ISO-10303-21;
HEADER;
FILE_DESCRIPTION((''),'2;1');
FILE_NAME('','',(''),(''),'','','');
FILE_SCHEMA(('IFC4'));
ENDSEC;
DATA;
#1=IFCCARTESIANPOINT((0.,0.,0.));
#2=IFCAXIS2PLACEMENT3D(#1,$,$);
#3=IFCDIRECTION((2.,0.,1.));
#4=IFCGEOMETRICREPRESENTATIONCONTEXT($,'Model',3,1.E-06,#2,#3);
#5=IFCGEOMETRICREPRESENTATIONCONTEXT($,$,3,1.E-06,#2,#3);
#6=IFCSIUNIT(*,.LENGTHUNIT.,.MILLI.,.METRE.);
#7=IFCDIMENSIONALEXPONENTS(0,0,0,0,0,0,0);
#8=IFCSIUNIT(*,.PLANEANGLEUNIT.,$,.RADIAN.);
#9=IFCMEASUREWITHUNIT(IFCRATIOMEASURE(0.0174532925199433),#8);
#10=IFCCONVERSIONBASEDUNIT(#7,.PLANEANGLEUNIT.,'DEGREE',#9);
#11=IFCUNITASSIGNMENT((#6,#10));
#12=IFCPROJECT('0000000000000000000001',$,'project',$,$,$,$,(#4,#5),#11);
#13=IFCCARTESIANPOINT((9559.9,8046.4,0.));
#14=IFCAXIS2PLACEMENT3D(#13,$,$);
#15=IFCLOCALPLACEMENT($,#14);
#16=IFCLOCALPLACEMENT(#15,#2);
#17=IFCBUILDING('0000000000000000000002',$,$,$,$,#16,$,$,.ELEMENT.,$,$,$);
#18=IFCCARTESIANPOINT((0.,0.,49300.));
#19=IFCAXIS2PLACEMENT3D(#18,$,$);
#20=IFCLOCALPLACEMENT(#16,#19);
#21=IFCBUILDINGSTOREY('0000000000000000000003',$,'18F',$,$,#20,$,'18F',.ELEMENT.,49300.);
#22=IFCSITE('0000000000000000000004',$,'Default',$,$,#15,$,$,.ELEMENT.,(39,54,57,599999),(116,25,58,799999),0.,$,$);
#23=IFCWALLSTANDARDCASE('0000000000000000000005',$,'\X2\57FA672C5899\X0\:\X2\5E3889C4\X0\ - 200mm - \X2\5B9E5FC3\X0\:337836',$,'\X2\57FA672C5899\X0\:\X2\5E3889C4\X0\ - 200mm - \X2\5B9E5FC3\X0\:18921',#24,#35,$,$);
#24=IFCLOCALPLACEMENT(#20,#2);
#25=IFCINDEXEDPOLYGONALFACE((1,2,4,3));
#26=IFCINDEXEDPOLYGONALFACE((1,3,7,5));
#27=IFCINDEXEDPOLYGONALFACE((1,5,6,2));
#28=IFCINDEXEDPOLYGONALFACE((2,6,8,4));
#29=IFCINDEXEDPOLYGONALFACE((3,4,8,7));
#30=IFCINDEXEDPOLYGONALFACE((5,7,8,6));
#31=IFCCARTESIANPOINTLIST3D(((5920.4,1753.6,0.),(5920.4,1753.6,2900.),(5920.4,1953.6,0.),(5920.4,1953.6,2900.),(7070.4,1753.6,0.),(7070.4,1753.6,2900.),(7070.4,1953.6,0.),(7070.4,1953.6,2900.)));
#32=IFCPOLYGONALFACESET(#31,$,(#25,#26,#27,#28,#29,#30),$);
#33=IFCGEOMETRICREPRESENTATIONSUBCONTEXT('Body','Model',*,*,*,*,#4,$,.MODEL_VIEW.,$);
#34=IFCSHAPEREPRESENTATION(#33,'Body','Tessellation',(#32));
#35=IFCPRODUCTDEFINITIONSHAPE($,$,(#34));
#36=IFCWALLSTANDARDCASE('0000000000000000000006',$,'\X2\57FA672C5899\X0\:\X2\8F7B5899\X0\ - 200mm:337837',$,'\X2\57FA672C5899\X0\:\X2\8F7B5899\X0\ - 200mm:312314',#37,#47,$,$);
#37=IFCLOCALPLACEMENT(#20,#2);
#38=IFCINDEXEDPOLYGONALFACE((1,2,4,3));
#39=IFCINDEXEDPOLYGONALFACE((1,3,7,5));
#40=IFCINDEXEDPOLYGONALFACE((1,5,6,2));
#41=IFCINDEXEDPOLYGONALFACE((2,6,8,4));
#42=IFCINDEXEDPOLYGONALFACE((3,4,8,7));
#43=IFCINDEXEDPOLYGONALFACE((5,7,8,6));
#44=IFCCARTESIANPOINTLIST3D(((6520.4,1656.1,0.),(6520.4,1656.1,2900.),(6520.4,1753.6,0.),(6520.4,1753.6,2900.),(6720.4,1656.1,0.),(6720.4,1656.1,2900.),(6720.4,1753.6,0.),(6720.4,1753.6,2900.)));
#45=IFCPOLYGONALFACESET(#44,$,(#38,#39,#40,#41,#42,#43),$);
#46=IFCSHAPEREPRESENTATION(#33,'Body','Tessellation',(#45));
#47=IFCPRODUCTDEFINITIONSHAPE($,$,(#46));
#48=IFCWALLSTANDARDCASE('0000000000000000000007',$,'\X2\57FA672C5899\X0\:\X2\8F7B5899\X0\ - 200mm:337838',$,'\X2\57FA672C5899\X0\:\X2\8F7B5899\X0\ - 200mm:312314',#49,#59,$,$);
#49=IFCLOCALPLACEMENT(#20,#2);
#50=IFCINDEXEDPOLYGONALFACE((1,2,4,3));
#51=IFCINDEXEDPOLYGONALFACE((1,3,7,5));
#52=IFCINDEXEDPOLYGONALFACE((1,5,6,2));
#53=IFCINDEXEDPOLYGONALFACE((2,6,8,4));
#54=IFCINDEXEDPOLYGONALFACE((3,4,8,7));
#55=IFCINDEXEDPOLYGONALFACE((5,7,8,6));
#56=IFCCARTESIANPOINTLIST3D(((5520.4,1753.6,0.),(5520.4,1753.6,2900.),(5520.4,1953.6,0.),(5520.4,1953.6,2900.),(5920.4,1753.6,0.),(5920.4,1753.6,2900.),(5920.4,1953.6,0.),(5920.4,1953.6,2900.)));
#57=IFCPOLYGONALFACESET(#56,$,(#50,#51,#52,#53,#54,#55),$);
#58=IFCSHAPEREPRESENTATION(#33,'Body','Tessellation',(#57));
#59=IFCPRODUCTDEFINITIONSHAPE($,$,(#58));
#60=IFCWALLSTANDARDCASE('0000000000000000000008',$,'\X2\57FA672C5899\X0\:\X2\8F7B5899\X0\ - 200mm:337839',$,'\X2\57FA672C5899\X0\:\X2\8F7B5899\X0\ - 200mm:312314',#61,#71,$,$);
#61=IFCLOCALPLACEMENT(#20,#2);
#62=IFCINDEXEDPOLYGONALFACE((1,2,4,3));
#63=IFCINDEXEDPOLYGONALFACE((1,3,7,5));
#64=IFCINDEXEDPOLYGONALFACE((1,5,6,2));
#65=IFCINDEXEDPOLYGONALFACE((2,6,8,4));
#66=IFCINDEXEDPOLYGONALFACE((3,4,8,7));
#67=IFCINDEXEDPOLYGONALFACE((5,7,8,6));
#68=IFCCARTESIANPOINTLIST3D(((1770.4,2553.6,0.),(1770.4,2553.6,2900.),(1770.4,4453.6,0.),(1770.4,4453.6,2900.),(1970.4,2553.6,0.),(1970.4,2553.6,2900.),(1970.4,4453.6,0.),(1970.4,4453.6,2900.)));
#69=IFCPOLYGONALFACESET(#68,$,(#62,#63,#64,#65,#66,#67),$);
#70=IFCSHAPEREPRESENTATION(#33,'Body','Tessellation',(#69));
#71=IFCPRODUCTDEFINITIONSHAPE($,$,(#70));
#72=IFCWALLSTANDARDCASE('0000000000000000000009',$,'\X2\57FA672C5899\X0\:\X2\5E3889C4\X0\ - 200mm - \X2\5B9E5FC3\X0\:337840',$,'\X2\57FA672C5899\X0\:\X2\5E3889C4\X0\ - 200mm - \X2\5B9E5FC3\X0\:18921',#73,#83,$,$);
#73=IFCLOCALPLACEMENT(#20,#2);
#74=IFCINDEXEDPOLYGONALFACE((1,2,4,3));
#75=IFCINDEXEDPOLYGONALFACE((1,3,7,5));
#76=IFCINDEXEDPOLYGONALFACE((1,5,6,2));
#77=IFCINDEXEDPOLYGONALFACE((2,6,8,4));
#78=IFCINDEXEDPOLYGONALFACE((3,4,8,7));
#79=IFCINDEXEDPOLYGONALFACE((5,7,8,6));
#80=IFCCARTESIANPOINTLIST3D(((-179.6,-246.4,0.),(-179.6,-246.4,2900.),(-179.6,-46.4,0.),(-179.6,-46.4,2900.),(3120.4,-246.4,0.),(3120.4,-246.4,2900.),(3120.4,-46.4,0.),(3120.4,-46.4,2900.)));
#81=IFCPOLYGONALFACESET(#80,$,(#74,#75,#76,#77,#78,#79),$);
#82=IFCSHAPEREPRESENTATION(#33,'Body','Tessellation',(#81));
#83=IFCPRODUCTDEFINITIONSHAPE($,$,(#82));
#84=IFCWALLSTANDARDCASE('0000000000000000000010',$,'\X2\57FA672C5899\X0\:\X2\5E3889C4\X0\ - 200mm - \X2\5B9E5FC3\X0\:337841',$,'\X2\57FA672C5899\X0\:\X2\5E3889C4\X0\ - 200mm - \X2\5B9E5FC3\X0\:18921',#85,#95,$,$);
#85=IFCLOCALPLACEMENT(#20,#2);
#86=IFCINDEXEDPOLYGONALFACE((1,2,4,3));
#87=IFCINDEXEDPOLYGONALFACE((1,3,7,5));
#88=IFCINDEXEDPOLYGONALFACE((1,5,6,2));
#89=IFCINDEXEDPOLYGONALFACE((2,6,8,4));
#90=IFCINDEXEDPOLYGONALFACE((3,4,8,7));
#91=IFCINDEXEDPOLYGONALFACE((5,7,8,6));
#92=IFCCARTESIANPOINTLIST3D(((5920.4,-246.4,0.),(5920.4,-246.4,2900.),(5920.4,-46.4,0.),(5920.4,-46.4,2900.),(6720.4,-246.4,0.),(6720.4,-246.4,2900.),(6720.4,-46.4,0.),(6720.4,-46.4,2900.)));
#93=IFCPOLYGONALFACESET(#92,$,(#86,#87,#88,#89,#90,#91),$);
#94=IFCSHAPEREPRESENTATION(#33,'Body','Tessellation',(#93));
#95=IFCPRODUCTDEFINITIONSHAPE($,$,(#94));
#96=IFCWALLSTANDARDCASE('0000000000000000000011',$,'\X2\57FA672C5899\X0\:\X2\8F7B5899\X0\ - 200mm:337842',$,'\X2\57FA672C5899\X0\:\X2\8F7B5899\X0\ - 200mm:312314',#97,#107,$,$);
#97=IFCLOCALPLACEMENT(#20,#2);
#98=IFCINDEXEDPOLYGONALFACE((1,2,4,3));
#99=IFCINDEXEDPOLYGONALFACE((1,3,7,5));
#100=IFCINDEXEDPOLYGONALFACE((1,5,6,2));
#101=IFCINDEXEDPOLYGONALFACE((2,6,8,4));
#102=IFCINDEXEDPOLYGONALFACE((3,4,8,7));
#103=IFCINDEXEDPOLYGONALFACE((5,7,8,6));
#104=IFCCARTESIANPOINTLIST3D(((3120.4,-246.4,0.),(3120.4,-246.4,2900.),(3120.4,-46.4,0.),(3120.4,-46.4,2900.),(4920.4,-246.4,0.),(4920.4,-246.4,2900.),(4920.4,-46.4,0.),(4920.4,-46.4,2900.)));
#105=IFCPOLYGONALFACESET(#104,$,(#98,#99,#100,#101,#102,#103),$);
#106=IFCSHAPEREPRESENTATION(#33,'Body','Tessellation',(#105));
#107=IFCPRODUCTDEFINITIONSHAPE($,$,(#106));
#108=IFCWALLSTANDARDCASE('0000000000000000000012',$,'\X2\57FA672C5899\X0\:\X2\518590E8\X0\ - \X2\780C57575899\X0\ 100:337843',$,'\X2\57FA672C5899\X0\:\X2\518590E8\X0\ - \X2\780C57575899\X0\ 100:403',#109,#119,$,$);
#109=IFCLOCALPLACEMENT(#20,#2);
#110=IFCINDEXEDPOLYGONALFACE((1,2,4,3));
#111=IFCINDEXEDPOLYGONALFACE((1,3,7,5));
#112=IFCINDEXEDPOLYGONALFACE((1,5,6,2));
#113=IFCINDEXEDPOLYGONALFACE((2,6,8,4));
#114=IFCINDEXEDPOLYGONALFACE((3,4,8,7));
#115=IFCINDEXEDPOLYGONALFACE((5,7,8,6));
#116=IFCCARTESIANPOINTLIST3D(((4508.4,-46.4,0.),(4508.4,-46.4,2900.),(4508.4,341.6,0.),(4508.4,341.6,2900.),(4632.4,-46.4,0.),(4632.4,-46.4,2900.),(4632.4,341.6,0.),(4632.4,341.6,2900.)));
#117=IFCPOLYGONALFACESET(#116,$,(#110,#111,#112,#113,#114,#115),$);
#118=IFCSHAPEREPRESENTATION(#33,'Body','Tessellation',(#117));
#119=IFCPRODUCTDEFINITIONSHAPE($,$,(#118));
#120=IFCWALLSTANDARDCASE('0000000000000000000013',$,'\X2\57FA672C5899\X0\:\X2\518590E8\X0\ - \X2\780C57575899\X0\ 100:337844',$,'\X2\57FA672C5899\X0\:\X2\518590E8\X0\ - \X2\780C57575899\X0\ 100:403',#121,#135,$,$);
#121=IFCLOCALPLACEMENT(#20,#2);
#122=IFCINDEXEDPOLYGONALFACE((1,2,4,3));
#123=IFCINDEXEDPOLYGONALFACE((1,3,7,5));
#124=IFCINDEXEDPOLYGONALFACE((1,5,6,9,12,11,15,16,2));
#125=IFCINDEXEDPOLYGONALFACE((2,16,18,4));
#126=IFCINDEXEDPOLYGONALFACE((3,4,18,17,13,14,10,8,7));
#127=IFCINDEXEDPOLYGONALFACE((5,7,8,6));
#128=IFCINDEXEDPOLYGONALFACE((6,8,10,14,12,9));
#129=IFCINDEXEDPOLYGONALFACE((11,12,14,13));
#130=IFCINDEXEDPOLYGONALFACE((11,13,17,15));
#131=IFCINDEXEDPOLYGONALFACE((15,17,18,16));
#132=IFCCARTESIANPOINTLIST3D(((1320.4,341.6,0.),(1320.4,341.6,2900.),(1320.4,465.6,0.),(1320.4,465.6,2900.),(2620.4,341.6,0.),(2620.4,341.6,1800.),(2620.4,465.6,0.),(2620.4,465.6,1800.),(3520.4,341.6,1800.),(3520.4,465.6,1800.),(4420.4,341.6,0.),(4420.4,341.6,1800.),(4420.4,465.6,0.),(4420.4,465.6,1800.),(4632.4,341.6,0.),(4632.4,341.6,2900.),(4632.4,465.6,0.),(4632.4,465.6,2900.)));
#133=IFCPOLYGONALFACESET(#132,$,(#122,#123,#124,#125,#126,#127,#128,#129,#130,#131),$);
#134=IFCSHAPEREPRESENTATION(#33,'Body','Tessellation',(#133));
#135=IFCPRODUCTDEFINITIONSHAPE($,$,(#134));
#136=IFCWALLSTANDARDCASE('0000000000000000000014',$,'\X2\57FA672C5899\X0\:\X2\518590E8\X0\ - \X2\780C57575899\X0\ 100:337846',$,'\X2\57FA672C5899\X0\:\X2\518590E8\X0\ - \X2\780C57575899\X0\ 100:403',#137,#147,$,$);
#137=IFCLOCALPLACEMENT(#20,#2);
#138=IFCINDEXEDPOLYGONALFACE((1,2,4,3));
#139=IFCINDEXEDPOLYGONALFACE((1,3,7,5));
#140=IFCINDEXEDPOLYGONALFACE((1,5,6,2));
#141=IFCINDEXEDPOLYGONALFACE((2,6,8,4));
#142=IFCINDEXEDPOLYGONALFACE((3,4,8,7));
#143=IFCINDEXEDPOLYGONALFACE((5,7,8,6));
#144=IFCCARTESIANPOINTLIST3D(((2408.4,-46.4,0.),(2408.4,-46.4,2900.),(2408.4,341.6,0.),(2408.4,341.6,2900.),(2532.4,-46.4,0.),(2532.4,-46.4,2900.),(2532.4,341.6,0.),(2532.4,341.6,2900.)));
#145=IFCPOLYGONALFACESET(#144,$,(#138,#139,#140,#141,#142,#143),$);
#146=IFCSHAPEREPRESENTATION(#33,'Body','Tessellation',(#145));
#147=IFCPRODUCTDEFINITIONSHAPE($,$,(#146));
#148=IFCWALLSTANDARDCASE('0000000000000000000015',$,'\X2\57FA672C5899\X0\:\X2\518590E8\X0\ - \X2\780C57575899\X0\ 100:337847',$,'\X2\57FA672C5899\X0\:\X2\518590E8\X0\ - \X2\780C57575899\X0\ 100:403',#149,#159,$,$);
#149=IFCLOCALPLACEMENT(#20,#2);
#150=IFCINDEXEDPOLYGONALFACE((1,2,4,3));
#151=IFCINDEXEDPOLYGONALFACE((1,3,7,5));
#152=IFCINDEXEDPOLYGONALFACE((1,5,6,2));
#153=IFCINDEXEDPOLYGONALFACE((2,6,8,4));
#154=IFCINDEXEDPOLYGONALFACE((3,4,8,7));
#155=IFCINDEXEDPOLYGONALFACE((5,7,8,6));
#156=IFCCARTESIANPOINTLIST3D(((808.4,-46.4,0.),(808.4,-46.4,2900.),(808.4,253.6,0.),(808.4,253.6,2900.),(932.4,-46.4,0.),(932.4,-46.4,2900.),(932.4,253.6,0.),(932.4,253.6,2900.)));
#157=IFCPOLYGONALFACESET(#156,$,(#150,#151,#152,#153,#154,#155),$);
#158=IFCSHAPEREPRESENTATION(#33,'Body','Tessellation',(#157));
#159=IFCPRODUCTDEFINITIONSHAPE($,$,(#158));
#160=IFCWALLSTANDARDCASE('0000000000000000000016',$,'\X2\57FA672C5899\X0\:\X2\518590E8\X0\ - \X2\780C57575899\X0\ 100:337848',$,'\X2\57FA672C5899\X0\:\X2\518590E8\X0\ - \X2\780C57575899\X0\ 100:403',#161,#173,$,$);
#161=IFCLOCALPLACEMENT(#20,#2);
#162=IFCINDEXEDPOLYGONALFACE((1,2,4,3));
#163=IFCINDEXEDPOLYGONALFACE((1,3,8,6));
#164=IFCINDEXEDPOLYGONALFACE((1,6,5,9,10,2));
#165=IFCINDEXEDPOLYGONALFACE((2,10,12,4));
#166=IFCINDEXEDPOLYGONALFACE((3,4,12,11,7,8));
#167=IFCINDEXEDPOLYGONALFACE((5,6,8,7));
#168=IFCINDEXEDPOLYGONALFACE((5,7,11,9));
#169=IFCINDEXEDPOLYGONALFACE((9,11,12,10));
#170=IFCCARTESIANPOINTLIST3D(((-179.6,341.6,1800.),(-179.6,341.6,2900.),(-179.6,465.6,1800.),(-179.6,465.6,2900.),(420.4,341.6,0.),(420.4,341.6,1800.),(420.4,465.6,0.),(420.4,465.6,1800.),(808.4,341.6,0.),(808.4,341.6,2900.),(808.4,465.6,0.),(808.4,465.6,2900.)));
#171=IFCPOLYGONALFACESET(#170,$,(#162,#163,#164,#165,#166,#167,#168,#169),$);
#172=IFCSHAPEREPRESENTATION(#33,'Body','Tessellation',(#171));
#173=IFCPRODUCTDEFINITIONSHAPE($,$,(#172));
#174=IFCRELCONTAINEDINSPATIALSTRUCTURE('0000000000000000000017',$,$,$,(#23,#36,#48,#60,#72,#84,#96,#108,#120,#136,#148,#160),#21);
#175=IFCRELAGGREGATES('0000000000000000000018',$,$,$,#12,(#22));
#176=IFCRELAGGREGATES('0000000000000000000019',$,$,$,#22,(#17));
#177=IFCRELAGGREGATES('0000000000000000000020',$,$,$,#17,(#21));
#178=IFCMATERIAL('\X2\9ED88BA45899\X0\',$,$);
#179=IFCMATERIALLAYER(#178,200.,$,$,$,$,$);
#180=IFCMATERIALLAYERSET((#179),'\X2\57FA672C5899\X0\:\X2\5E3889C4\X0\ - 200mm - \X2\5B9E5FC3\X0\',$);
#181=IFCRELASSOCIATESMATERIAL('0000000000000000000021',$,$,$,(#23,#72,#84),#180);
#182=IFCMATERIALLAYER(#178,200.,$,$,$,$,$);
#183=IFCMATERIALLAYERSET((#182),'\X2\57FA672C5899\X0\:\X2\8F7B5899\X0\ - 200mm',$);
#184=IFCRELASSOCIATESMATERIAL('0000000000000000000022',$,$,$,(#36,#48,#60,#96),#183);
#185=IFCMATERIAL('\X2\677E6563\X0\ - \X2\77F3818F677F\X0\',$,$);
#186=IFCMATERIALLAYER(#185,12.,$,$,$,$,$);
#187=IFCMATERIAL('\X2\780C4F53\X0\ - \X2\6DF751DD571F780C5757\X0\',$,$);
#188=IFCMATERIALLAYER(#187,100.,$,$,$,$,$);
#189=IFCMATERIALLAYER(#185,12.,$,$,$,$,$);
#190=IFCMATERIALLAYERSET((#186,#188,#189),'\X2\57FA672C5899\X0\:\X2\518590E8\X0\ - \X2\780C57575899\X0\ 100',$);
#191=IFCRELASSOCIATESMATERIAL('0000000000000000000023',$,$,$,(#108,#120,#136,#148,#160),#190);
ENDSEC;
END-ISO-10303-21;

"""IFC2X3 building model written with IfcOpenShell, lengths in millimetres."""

from ifc_helpers import new_model, entity, si_unit, converted_unit, direction, frame, frame_2d, origin, place, context, subcontext, project, spatial, rectangle, extrude, material, layer, layer_set, layer_usage, element, save


model = new_model("IFC2X3")

# Units and contexts
model_context = context("Model", 3, precision=1e-06, world=origin(), true_north=direction((2.0, 0.0, 1.0)))
context_of_model = context(None, 3, precision=1e-06, world=origin(), true_north=direction((2.0, 0.0, 1.0)))
body_context = subcontext(model_context, "Body", "Model", "MODEL_VIEW")
ifc_project = project(units=[si_unit("LENGTHUNIT", "METRE", prefix="MILLI"), converted_unit("PLANEANGLEUNIT", "DEGREE", entity("IfcRatioMeasure", 0.0174532925199433), si_unit("PLANEANGLEUNIT", "RADIAN"), dimensions=[0, 0, 0, 0, 0, 0, 0])], contexts=[model_context, context_of_model])

# Site, building, storey
site_placement = place(None, frame((9559.9, 8046.4, 0.0)))
site = spatial("IfcSite", under=ifc_project, at=site_placement, Name="Default", CompositionType="ELEMENT", RefLatitude=(39, 54, 57, 599999), RefLongitude=(116, 25, 58, 799999), RefElevation=0.0)
building_placement = place(site_placement, origin())
building = spatial("IfcBuilding", under=site, at=building_placement, CompositionType="ELEMENT")
storey_placement = place(building_placement, frame((0.0, 0.0, 49300.0)))
storey = spatial("IfcBuildingStorey", under=building, at=storey_placement, Name="18F", LongName="18F", CompositionType="ELEMENT", Elevation=49300.0)

# Shared definitions
ifc_material_1 = material(Name="默认墙")
ifc_layer_1 = layer(ifc_material_1, 200.0)
ifc_layer_set_1 = layer_set([ifc_layer_1], Name="基本墙:常规 - 200mm - 实心")

# Walls
ifc_layer_usage_1 = layer_usage(ifc_layer_set_1, "AXIS2", "NEGATIVE", 100.0)
wall_1_placement = place(storey_placement, frame((5920.4, 1853.6, 0.0)))
element("IfcWallStandardCase", 1, at=wall_1_placement, inside=storey, material=ifc_layer_usage_1, Name="基本墙:常规 - 200mm - 实心:337836", ObjectType="基本墙:常规 - 200mm - 实心:18921", context=body_context, shape_type="SweptSolid", body=[
    extrude(rectangle(XDim=1150.0, YDim=200.0, at=frame_2d((575.0, 0.0), x_axis=(-1.0, 0.0))), origin(), (0.0, 0.0, 1.0), 2900.0),
])
ifc_layer_2 = layer(ifc_material_1, 200.0)
ifc_layer_set_2 = layer_set([ifc_layer_2], Name="基本墙:轻墙 - 200mm")
ifc_layer_usage_2 = layer_usage(ifc_layer_set_2, "AXIS2", "NEGATIVE", 100.0)
wall_2_placement = place(storey_placement, frame((6620.4, 1753.6, 0.0), z_axis=(0.0, 0.0, 1.0), x_axis=(0.0, -1.0, 0.0)))
element("IfcWallStandardCase", 2, at=wall_2_placement, inside=storey, material=ifc_layer_usage_2, Name="基本墙:轻墙 - 200mm:337837", ObjectType="基本墙:轻墙 - 200mm:312314", context=body_context, shape_type="SweptSolid", body=[
    extrude(rectangle(XDim=97.5, YDim=200.0, at=frame_2d((48.8, 0.0), x_axis=(-1.0, 0.0))), origin(), (0.0, 0.0, 1.0), 2900.0),
])
ifc_layer_usage_3 = layer_usage(ifc_layer_set_2, "AXIS2", "NEGATIVE", 100.0)
wall_3_placement = place(storey_placement, frame((5920.4, 1853.6, 0.0), z_axis=(0.0, 0.0, 1.0), x_axis=(-1.0, 0.0, 0.0)))
element("IfcWallStandardCase", 3, at=wall_3_placement, inside=storey, material=ifc_layer_usage_3, Name="基本墙:轻墙 - 200mm:337838", ObjectType="基本墙:轻墙 - 200mm:312314", context=body_context, shape_type="SweptSolid", body=[
    extrude(rectangle(XDim=400.0, YDim=200.0, at=frame_2d((200.0, 0.0), x_axis=(-1.0, 0.0))), origin(), (0.0, 0.0, 1.0), 2900.0),
])
ifc_layer_usage_4 = layer_usage(ifc_layer_set_2, "AXIS2", "NEGATIVE", 100.0)
wall_4_placement = place(storey_placement, frame((1870.4, 4453.6, 0.0), z_axis=(0.0, 0.0, 1.0), x_axis=(0.0, -1.0, 0.0)))
element("IfcWallStandardCase", 4, at=wall_4_placement, inside=storey, material=ifc_layer_usage_4, Name="基本墙:轻墙 - 200mm:337839", ObjectType="基本墙:轻墙 - 200mm:312314", context=body_context, shape_type="SweptSolid", body=[
    extrude(rectangle(XDim=1900.0, YDim=200.0, at=frame_2d((950.0, 0.0), x_axis=(-1.0, 0.0))), origin(), (0.0, 0.0, 1.0), 2900.0),
])
ifc_layer_usage_5 = layer_usage(ifc_layer_set_1, "AXIS2", "NEGATIVE", 100.0)
wall_5_placement = place(storey_placement, frame((-179.6, -146.4, 0.0)))
element("IfcWallStandardCase", 5, at=wall_5_placement, inside=storey, material=ifc_layer_usage_5, Name="基本墙:常规 - 200mm - 实心:337840", ObjectType="基本墙:常规 - 200mm - 实心:18921", context=body_context, shape_type="SweptSolid", body=[
    extrude(rectangle(XDim=3300.0, YDim=200.0, at=frame_2d((1650.0, 0.0), x_axis=(-1.0, 0.0))), origin(), (0.0, 0.0, 1.0), 2900.0),
])
ifc_layer_usage_6 = layer_usage(ifc_layer_set_1, "AXIS2", "NEGATIVE", 100.0)
wall_6_placement = place(storey_placement, frame((6720.4, -146.4, 0.0), z_axis=(0.0, 0.0, 1.0), x_axis=(-1.0, 0.0, 0.0)))
element("IfcWallStandardCase", 6, at=wall_6_placement, inside=storey, material=ifc_layer_usage_6, Name="基本墙:常规 - 200mm - 实心:337841", ObjectType="基本墙:常规 - 200mm - 实心:18921", context=body_context, shape_type="SweptSolid", body=[
    extrude(rectangle(XDim=800.0, YDim=200.0, at=frame_2d((400.0, 0.0), x_axis=(-1.0, 0.0))), origin(), (0.0, 0.0, 1.0), 2900.0),
])
ifc_layer_usage_7 = layer_usage(ifc_layer_set_2, "AXIS2", "NEGATIVE", 100.0)
wall_7_placement = place(storey_placement, frame((3120.4, -146.4, 0.0)))
element("IfcWallStandardCase", 7, at=wall_7_placement, inside=storey, material=ifc_layer_usage_7, Name="基本墙:轻墙 - 200mm:337842", ObjectType="基本墙:轻墙 - 200mm:312314", context=body_context, shape_type="SweptSolid", body=[
    extrude(rectangle(XDim=1800.0, YDim=200.0, at=frame_2d((900.0, 0.0), x_axis=(-1.0, 0.0))), origin(), (0.0, 0.0, 1.0), 2900.0),
])
ifc_material_2 = material(Name="松散 - 石膏板")
ifc_layer_3 = layer(ifc_material_2, 12.0)
ifc_material_3 = material(Name="砌体 - 混凝土砌块")
ifc_layer_4 = layer(ifc_material_3, 100.0)
ifc_layer_5 = layer(ifc_material_2, 12.0)
ifc_layer_set_3 = layer_set([ifc_layer_3, ifc_layer_4, ifc_layer_5], Name="基本墙:内部 - 砌块墙 100")
ifc_layer_usage_8 = layer_usage(ifc_layer_set_3, "AXIS2", "NEGATIVE", 62.0)
wall_8_placement = place(storey_placement, frame((4570.4, -46.4, 0.0), z_axis=(0.0, 0.0, 1.0), x_axis=(0.0, 1.0, 0.0)))
element("IfcWallStandardCase", 8, at=wall_8_placement, inside=storey, material=ifc_layer_usage_8, Name="基本墙:内部 - 砌块墙 100:337843", ObjectType="基本墙:内部 - 砌块墙 100:403", context=body_context, shape_type="SweptSolid", body=[
    extrude(rectangle(XDim=388.0, YDim=124.0, at=frame_2d((194.0, 0.0), x_axis=(-1.0, 0.0))), origin(), (0.0, 0.0, 1.0), 2900.0),
])

# Wall, openings
ifc_layer_usage_9 = layer_usage(ifc_layer_set_3, "AXIS2", "NEGATIVE", 62.0)
wall_9_placement = place(storey_placement, frame((4632.4, 403.6, 0.0), z_axis=(0.0, 0.0, 1.0), x_axis=(-1.0, 0.0, 0.0)))
wall_9 = element("IfcWallStandardCase", 9, at=wall_9_placement, inside=storey, material=ifc_layer_usage_9, Name="基本墙:内部 - 砌块墙 100:337844", ObjectType="基本墙:内部 - 砌块墙 100:403", context=body_context, shape_type="SweptSolid", body=[
    extrude(rectangle(XDim=3312.0, YDim=124.0, at=frame_2d((1656.0, 0.0), x_axis=(-1.0, 0.0))), origin(), (0.0, 0.0, 1.0), 2900.0),
])
opening_1_placement = place(wall_9_placement, frame((2012.0, 62.0, 0.0)))
element("IfcOpeningElement", 10, at=opening_1_placement, cuts=wall_9, ObjectType="Opening", context=body_context, shape_type="SweptSolid", body=[
    extrude(rectangle(XDim=1800.0, YDim=900.0, at=frame_2d((900.0, 450.0), x_axis=(1.0, 0.0))), frame((0.0, 0.0, 0.0), z_axis=(0.0, -1.0, 0.0), x_axis=(0.0, 0.0, 1.0)), (0.0, 0.0, 1.0), 124.0),
])
opening_2_placement = place(wall_9_placement, frame((1112.0, 62.0, 0.0)))
element("IfcOpeningElement", 11, at=opening_2_placement, cuts=wall_9, ObjectType="Opening", context=body_context, shape_type="SweptSolid", body=[
    extrude(rectangle(XDim=1800.0, YDim=900.0, at=frame_2d((900.0, 450.0), x_axis=(1.0, 0.0))), frame((0.0, 0.0, 0.0), z_axis=(0.0, -1.0, 0.0), x_axis=(0.0, 0.0, 1.0)), (0.0, 0.0, 1.0), 124.0),
])

# Walls
ifc_layer_usage_10 = layer_usage(ifc_layer_set_3, "AXIS2", "NEGATIVE", 62.0)
wall_10_placement = place(storey_placement, frame((2470.4, 341.6, 0.0), z_axis=(0.0, 0.0, 1.0), x_axis=(0.0, -1.0, 0.0)))
element("IfcWallStandardCase", 12, at=wall_10_placement, inside=storey, material=ifc_layer_usage_10, Name="基本墙:内部 - 砌块墙 100:337846", ObjectType="基本墙:内部 - 砌块墙 100:403", context=body_context, shape_type="SweptSolid", body=[
    extrude(rectangle(XDim=388.0, YDim=124.0, at=frame_2d((194.0, 0.0), x_axis=(-1.0, 0.0))), origin(), (0.0, 0.0, 1.0), 2900.0),
])
ifc_layer_usage_11 = layer_usage(ifc_layer_set_3, "AXIS2", "NEGATIVE", 62.0)
wall_11_placement = place(storey_placement, frame((870.4, -46.4, 0.0), z_axis=(0.0, 0.0, 1.0), x_axis=(0.0, 1.0, 0.0)))
element("IfcWallStandardCase", 13, at=wall_11_placement, inside=storey, material=ifc_layer_usage_11, Name="基本墙:内部 - 砌块墙 100:337847", ObjectType="基本墙:内部 - 砌块墙 100:403", context=body_context, shape_type="SweptSolid", body=[
    extrude(rectangle(XDim=300.0, YDim=124.0, at=frame_2d((150.0, 0.0), x_axis=(-1.0, 0.0))), origin(), (0.0, 0.0, 1.0), 2900.0),
])

# Wall, opening
ifc_layer_usage_12 = layer_usage(ifc_layer_set_3, "AXIS2", "NEGATIVE", 62.0)
wall_12_placement = place(storey_placement, frame((808.4, 403.6, 0.0), z_axis=(0.0, 0.0, 1.0), x_axis=(-1.0, 0.0, 0.0)))
wall_12 = element("IfcWallStandardCase", 14, at=wall_12_placement, inside=storey, material=ifc_layer_usage_12, Name="基本墙:内部 - 砌块墙 100:337848", ObjectType="基本墙:内部 - 砌块墙 100:403", context=body_context, shape_type="SweptSolid", body=[
    extrude(rectangle(XDim=988.0, YDim=124.0, at=frame_2d((494.0, 0.0), x_axis=(-1.0, 0.0))), origin(), (0.0, 0.0, 1.0), 2900.0),
])
opening_3_placement = place(wall_12_placement, frame((988.0, 62.0, 0.0)))
element("IfcOpeningElement", 15, at=opening_3_placement, cuts=wall_12, ObjectType="Opening", context=body_context, shape_type="SweptSolid", body=[
    extrude(rectangle(XDim=1800.0, YDim=600.0, at=frame_2d((900.0, 300.0), x_axis=(1.0, 0.0))), frame((0.0, 0.0, 0.0), z_axis=(0.0, -1.0, 0.0), x_axis=(0.0, 0.0, 1.0)), (0.0, 0.0, 1.0), 124.0),
])

save(model, "model.ifc")
